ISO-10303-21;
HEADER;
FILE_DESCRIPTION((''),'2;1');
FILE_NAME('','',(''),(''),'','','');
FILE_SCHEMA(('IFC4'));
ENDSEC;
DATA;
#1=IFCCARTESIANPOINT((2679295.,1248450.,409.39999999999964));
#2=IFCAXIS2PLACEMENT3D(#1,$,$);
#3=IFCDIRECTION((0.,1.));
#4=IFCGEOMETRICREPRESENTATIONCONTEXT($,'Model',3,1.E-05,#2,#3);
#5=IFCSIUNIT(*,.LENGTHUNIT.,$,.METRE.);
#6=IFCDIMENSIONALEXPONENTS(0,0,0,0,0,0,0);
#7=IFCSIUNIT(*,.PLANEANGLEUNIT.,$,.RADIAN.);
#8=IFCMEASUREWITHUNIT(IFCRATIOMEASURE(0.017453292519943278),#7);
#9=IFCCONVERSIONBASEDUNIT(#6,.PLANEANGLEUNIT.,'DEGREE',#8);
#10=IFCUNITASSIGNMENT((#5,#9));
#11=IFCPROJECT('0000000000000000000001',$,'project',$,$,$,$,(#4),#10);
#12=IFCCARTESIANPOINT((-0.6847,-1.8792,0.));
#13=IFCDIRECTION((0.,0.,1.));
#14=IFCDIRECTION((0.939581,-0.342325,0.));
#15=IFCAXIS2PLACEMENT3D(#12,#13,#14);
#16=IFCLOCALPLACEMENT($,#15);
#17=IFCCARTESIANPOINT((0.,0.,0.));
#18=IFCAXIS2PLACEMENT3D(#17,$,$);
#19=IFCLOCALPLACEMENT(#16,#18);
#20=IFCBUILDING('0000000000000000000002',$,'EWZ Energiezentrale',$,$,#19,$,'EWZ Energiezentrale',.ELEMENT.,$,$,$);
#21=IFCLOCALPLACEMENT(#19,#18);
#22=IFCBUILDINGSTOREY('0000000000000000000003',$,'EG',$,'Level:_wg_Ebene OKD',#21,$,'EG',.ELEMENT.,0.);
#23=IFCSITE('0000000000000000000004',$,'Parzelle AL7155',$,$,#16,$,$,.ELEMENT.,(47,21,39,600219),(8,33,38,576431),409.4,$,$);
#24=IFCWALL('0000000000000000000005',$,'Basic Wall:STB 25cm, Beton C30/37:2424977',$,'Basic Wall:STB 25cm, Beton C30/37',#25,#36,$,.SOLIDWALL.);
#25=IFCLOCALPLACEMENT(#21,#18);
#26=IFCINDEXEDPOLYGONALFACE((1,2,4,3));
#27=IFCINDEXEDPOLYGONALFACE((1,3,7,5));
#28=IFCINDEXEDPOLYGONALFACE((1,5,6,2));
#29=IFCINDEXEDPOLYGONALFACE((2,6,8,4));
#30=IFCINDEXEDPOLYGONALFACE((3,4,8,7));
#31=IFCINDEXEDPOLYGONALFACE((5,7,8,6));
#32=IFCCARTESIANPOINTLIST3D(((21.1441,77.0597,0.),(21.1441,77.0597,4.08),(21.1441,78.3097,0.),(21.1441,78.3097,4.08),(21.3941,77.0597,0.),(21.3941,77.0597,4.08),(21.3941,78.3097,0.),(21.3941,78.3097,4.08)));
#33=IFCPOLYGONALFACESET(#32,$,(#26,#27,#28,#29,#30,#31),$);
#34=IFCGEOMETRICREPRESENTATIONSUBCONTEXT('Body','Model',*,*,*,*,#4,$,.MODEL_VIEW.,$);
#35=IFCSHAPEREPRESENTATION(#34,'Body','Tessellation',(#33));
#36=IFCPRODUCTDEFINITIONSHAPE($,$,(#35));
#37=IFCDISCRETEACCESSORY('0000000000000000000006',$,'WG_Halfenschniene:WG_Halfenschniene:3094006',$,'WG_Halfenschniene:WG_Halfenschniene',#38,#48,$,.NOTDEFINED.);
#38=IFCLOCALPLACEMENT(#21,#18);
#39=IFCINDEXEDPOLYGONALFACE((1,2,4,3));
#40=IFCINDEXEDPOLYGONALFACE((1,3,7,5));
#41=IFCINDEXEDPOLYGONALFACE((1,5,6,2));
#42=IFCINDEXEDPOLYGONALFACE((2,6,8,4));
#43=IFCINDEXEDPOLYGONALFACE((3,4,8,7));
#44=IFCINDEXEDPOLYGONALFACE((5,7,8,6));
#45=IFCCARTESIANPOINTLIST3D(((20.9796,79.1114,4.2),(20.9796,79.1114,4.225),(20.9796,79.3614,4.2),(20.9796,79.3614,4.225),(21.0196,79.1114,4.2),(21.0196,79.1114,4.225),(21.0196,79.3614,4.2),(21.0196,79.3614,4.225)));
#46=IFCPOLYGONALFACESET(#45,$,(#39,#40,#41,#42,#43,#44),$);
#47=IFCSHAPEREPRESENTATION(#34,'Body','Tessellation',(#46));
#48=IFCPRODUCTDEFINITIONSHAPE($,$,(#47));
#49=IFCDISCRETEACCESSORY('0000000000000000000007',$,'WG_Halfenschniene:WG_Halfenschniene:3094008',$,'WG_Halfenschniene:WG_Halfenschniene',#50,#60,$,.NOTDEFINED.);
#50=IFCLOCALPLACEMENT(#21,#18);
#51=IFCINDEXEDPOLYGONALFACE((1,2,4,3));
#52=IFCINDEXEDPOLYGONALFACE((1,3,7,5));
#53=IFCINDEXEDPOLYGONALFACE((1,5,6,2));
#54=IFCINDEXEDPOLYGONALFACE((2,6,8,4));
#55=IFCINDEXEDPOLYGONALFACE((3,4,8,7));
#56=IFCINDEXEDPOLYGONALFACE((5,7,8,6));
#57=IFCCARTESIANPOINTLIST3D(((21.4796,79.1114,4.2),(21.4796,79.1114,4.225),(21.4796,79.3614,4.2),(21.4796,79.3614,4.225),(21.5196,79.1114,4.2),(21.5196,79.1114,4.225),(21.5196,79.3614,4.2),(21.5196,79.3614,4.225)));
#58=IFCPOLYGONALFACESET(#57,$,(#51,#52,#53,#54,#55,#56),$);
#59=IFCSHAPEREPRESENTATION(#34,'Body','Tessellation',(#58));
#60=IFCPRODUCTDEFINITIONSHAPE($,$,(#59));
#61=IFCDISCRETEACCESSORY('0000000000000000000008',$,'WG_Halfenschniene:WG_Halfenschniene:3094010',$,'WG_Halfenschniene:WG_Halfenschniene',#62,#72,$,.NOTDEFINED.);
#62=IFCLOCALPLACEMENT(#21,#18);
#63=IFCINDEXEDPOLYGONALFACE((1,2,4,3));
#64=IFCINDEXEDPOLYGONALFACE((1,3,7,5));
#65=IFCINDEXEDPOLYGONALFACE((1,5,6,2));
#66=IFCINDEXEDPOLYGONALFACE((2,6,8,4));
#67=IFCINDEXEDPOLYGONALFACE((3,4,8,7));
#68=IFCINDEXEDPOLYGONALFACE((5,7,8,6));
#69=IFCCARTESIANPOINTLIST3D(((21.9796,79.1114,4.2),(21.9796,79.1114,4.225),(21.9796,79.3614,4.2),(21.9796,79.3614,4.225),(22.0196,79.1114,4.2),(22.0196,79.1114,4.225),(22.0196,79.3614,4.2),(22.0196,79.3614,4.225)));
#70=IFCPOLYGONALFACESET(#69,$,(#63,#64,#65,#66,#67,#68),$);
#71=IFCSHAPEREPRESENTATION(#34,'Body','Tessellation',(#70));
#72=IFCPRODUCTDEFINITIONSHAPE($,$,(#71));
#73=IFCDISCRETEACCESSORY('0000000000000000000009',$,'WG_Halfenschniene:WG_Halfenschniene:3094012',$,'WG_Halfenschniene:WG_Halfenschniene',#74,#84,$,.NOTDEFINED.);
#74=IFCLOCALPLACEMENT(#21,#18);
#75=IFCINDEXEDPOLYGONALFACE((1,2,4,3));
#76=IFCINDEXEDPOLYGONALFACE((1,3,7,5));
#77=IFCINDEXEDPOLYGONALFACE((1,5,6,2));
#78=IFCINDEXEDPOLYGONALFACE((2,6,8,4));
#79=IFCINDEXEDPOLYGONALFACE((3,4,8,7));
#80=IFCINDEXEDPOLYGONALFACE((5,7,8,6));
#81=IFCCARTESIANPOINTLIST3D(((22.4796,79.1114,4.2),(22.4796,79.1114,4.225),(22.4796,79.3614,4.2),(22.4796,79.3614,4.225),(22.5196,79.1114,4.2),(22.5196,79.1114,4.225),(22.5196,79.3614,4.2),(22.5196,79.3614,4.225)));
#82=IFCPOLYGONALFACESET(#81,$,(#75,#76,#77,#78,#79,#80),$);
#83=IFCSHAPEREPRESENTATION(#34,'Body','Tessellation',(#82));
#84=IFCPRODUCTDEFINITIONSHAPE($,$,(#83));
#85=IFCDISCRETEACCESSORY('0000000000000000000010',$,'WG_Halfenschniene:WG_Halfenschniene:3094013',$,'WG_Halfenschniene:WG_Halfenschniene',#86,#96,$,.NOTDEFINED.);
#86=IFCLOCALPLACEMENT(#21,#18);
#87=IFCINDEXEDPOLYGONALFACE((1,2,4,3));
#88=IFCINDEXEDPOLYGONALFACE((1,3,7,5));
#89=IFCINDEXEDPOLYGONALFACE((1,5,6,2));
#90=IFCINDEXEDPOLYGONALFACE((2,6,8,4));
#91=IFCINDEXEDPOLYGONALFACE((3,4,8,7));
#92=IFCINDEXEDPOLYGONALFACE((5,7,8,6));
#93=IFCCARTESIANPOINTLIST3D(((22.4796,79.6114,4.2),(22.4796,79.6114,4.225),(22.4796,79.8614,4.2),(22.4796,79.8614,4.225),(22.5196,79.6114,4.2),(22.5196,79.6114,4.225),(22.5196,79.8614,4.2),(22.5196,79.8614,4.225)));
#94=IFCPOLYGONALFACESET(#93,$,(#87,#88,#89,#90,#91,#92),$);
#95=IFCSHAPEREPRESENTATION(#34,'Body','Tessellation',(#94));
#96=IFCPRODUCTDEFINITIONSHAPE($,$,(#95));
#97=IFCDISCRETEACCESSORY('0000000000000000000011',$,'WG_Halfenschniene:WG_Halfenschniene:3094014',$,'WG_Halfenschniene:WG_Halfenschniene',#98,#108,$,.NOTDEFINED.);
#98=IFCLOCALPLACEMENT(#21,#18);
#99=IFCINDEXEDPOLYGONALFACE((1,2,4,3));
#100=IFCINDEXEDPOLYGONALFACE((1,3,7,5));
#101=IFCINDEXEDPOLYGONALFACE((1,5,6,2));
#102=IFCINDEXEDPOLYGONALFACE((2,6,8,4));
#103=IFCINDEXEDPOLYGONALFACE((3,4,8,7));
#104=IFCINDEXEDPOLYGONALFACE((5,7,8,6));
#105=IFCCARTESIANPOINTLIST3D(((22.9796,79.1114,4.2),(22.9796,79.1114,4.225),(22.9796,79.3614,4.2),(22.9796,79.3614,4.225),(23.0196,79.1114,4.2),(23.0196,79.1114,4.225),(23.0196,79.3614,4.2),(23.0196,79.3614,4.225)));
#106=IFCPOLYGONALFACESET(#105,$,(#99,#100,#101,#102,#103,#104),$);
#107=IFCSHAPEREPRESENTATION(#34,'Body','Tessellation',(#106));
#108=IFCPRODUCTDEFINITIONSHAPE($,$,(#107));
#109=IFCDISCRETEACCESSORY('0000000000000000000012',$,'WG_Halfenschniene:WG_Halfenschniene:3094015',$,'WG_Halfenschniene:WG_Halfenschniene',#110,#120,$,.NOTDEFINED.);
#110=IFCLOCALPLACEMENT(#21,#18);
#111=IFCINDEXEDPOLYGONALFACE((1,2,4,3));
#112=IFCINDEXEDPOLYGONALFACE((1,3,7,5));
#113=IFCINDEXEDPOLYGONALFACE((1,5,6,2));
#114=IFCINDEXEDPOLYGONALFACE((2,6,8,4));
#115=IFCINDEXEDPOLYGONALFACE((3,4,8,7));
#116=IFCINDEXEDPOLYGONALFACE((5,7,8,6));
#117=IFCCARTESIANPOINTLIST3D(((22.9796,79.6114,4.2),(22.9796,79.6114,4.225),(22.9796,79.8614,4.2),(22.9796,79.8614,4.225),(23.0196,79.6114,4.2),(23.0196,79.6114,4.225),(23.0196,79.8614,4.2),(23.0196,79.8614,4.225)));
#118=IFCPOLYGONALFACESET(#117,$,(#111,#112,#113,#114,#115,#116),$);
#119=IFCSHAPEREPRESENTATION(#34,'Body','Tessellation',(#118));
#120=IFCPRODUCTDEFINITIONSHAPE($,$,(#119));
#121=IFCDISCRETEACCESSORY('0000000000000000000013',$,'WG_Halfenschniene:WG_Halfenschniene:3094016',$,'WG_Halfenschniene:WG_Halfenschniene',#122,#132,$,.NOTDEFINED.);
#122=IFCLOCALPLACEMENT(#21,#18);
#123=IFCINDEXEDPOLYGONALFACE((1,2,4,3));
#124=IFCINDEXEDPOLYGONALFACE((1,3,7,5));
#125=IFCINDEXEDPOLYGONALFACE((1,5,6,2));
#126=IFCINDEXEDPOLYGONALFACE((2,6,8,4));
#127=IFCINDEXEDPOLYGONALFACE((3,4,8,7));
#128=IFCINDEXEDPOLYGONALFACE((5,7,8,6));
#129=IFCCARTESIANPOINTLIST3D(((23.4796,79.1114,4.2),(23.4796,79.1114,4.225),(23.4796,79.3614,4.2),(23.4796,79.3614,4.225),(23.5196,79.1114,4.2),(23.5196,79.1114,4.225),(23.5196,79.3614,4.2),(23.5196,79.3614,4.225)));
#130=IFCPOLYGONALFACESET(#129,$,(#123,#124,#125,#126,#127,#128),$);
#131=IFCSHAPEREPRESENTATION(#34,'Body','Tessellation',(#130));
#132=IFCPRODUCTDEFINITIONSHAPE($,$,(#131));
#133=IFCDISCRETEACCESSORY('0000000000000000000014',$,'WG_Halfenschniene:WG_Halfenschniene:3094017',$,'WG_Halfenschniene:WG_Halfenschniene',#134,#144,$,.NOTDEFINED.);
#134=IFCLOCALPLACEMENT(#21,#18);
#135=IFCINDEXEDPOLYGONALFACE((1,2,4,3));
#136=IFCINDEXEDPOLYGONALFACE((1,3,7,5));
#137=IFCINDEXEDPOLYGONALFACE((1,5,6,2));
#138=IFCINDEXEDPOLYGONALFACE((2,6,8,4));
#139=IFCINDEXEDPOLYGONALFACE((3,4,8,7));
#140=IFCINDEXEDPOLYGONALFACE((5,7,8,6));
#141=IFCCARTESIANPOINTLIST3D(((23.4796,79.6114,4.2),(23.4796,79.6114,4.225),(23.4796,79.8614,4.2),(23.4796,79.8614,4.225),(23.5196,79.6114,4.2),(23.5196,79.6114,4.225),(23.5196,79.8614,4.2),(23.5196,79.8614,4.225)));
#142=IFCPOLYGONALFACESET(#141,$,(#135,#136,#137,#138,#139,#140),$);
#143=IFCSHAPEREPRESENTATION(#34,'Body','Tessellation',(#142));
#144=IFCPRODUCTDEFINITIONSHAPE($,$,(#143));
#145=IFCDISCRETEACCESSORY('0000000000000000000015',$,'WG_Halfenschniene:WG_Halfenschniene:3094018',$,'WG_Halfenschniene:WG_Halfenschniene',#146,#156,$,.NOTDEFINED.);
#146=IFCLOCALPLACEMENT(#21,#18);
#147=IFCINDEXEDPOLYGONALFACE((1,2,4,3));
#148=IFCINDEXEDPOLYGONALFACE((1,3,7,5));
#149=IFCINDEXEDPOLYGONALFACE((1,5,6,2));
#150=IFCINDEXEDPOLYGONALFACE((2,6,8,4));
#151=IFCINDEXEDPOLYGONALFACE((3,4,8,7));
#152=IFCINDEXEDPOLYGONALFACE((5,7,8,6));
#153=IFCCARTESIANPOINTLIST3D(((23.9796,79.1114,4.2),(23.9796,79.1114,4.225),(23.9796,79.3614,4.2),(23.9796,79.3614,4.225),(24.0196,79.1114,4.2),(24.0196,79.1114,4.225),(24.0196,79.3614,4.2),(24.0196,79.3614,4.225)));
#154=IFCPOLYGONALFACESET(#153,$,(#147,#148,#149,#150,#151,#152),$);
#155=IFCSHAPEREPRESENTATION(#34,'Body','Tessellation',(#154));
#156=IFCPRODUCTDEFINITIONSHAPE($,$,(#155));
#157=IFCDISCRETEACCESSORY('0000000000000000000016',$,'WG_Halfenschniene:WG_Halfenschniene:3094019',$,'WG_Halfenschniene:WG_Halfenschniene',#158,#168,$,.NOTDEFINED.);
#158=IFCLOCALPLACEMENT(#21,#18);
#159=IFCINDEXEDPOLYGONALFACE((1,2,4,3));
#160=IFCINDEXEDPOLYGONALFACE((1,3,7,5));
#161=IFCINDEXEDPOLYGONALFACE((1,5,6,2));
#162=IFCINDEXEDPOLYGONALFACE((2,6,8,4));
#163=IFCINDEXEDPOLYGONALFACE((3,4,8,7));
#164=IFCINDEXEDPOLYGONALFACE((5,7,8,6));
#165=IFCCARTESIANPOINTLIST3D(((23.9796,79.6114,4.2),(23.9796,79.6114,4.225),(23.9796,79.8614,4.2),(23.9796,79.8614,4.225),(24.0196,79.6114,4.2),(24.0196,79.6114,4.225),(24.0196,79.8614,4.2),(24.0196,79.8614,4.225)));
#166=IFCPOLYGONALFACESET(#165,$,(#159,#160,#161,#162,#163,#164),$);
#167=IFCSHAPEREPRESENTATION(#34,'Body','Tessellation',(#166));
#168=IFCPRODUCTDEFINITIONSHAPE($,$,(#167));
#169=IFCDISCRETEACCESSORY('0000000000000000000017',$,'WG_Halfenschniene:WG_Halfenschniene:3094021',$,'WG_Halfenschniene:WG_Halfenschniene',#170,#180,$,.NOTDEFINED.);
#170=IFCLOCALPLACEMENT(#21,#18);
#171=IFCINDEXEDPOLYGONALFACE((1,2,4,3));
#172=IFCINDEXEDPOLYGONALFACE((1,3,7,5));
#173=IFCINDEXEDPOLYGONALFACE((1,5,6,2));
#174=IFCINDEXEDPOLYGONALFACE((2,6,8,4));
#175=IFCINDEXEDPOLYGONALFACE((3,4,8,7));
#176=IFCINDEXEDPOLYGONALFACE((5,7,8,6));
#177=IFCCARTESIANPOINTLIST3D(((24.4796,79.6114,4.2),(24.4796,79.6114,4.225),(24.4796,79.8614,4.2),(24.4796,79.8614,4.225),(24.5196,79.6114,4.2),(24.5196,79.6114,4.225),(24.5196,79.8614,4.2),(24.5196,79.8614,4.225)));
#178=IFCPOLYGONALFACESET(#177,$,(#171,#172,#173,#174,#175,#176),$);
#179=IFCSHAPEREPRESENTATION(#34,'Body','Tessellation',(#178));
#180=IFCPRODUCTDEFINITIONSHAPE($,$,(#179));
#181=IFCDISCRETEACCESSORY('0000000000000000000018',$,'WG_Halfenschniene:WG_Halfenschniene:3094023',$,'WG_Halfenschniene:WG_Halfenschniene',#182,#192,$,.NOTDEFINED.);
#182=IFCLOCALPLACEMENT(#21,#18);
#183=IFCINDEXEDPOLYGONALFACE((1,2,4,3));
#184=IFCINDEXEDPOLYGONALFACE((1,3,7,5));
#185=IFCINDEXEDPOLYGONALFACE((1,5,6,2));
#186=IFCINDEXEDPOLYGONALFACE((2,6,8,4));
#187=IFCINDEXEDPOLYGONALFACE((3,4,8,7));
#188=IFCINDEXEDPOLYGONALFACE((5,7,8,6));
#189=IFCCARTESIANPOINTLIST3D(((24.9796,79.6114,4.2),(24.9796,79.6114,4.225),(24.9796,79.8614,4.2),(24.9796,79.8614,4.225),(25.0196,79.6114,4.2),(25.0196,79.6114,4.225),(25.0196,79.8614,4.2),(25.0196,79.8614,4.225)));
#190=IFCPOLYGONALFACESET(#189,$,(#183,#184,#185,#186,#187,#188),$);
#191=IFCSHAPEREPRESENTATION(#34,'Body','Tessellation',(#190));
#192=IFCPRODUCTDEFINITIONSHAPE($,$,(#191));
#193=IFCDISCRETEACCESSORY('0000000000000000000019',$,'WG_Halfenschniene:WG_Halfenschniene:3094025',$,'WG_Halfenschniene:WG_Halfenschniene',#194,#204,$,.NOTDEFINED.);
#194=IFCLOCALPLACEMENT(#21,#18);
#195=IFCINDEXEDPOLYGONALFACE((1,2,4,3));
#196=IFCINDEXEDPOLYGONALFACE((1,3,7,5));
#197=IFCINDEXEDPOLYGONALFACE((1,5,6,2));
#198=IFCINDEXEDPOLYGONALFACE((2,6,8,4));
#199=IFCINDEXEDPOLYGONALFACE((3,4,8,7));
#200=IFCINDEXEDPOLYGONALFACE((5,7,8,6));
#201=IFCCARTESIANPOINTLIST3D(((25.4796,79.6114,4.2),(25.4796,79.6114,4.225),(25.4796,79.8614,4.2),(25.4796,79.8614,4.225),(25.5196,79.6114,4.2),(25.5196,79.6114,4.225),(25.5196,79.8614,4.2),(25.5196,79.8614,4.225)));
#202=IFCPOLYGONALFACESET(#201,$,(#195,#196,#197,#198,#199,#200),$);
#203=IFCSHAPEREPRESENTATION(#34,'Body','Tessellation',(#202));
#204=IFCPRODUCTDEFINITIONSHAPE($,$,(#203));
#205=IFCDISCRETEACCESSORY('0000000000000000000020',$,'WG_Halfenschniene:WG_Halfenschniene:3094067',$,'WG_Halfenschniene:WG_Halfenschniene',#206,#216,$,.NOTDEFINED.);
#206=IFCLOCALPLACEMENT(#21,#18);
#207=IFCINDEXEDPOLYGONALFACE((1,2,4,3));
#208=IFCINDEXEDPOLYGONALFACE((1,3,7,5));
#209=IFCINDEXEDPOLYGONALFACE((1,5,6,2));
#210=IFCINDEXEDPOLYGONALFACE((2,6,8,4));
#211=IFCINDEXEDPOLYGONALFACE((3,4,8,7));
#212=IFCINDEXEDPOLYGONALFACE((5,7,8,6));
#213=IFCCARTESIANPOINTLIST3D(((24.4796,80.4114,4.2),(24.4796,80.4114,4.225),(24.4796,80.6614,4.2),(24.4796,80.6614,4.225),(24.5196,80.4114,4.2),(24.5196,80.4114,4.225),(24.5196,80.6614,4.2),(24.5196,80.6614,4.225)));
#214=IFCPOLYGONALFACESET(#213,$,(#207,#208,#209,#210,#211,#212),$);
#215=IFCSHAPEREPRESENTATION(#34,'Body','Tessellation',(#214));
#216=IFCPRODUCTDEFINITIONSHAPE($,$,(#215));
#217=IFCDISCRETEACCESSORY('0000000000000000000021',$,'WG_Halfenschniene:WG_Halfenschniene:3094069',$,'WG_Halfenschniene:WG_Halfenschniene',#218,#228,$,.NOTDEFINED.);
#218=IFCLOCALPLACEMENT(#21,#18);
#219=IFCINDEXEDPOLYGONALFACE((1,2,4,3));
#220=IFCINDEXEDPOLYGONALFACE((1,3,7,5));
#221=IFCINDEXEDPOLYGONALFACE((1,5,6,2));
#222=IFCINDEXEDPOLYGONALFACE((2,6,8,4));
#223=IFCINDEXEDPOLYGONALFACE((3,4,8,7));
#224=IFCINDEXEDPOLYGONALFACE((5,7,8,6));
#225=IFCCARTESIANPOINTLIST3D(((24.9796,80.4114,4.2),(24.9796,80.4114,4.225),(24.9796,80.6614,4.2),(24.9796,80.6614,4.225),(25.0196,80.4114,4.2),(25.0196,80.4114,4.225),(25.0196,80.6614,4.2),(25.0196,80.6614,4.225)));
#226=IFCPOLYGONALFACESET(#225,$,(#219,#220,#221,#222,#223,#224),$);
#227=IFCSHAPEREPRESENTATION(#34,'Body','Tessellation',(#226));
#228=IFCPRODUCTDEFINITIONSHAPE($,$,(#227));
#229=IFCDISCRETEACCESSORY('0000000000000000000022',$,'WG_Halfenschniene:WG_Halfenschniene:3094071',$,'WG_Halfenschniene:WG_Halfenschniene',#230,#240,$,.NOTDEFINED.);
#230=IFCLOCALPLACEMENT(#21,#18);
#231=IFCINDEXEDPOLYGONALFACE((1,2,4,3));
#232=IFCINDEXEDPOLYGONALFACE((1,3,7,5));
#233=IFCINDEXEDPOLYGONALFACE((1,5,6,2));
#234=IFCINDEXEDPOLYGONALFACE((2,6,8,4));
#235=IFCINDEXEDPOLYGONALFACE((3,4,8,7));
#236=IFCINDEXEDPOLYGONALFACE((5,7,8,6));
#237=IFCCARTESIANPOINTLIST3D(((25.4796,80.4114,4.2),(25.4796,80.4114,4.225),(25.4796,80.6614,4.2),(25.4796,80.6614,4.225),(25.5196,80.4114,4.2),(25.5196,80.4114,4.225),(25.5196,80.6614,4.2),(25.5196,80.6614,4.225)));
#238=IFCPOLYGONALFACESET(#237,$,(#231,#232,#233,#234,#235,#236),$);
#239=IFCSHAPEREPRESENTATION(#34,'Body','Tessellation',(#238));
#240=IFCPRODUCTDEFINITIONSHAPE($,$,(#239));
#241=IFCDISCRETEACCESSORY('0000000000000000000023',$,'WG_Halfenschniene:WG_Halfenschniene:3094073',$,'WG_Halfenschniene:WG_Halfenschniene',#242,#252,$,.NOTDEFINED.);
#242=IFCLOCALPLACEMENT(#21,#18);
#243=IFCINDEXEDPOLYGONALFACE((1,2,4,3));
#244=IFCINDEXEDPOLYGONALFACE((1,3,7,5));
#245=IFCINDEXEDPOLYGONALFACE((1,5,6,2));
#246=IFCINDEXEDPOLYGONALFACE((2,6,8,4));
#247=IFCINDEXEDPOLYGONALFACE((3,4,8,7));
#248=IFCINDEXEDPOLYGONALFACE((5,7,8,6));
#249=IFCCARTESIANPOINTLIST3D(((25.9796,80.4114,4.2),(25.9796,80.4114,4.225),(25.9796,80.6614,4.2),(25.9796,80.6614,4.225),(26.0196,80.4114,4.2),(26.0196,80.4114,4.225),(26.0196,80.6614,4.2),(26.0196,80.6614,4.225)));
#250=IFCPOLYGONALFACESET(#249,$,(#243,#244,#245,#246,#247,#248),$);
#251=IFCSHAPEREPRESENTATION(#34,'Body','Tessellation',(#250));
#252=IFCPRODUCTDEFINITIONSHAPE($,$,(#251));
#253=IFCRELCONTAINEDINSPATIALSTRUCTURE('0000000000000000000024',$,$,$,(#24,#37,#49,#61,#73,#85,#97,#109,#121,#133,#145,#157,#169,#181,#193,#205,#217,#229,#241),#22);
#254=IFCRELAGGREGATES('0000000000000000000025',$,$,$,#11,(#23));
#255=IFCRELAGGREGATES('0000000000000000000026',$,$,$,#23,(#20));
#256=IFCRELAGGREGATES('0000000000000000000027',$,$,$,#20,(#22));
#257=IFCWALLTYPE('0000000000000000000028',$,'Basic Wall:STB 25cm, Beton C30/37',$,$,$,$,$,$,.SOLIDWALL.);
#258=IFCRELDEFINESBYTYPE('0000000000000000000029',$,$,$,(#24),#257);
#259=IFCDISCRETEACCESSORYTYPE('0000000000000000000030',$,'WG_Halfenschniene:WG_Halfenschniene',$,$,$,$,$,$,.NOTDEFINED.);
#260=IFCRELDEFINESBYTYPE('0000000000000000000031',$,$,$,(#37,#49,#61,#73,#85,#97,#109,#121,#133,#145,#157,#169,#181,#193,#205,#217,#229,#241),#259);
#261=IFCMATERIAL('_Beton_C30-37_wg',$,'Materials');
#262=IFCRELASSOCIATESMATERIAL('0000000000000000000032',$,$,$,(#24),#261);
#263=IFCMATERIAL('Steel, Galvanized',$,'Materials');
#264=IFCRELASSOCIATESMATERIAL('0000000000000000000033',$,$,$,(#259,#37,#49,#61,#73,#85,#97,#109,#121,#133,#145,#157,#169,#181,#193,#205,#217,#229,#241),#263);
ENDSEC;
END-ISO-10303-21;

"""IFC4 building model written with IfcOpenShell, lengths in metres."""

from ifc_helpers import new_model, entity, si_unit, converted_unit, direction, frame, origin, place, context, subcontext, project, spatial, indexed_curve, outline, extrude, source, transform, mapped, material, type_object, element, save


model = new_model("IFC4")

# Units and contexts
model_context = context("Model", 3, precision=1e-05, world=frame((2679295.0, 1248450.0, 409.39999999999964)), true_north=direction((0.0, 1.0)))
body_context = subcontext(model_context, "Body", "Model", "MODEL_VIEW")
ifc_project = project(units=[si_unit("LENGTHUNIT", "METRE"), converted_unit("PLANEANGLEUNIT", "DEGREE", entity("IfcRatioMeasure", 0.017453292519943278), si_unit("PLANEANGLEUNIT", "RADIAN"), dimensions=[0, 0, 0, 0, 0, 0, 0])], contexts=[model_context])

# Site, building, storey
site_placement = place(None, frame((-0.6847, -1.8792, 0.0), z_axis=(0.0, 0.0, 1.0), x_axis=(0.939581, -0.342325, 0.0)))
site = spatial("IfcSite", under=ifc_project, at=site_placement, Name="Parzelle AL7155", CompositionType="ELEMENT", RefLatitude=(47, 21, 39, 600219), RefLongitude=(8, 33, 38, 576431), RefElevation=409.4)
building_placement = place(site_placement, origin())
building = spatial("IfcBuilding", under=site, at=building_placement, Name="EWZ Energiezentrale", LongName="EWZ Energiezentrale", CompositionType="ELEMENT")
storey_placement = place(building_placement, origin())
storey = spatial("IfcBuildingStorey", under=building, at=storey_placement, Name="EG", ObjectType="Level:_wg_Ebene OKD", LongName="EG", CompositionType="ELEMENT", Elevation=0.0)

# Wall
ifc_material_1 = material(Name="_Beton_C30-37_wg", Category="Materials")
wall_type = type_object("IfcWallType", Name="Basic Wall:STB 25cm, Beton C30/37", PredefinedType="SOLIDWALL")
wall_placement = place(storey_placement, frame((21.2691, 78.3097, 0.0), z_axis=(0.0, 0.0, 1.0), x_axis=(0.0, -1.0, 0.0)))
element("IfcWall", 1, at=wall_placement, inside=storey, type_object=wall_type, material=ifc_material_1, Name="Basic Wall:STB 25cm, Beton C30/37:2424977", ObjectType="Basic Wall:STB 25cm, Beton C30/37", PredefinedType="SOLIDWALL", context=body_context, shape_type="SweptSolid", body=[
    extrude(outline(indexed_curve([(1.25, 0.125), (0.0, 0.125), (0.0, -0.125), (1.25, -0.125), (1.25, 0.125)], self_intersect=False)), origin(), (0.0, 0.0, 1.0), 4.08),
])

# Discrete accessories
ifc_material_2 = material(Name="Steel, Galvanized", Category="Materials")
discrete_accessory_type = type_object("IfcDiscreteAccessoryType", Name="WG_Halfenschniene:WG_Halfenschniene", PredefinedType="NOTDEFINED", material=ifc_material_2)
shared_shape = source(origin(), body_context, "Body", "SweptSolid", [
    extrude(outline(indexed_curve([(-0.125, -0.02), (0.125, -0.02), (0.125, 0.02), (-0.125, 0.02), (-0.125, -0.02)], self_intersect=False)), frame((0.125, 0.0, -0.0125)), (0.0, 0.0, 1.0), 0.025),
])
for number, where, z_axis, x_axis, name in (
    (2, (20.9996, 79.1114, 4.2125), (0.0, 0.0, -1.0), (0.0, 1.0, 0.0), "WG_Halfenschniene:WG_Halfenschniene:3094006"),
    (3, (21.4996, 79.1114, 4.2125), (0.0, 0.0, -1.0), (0.0, 1.0, 0.0), "WG_Halfenschniene:WG_Halfenschniene:3094008"),
    (4, (21.9996, 79.1114, 4.2125), (0.0, 0.0, -1.0), (0.0, 1.0, 0.0), "WG_Halfenschniene:WG_Halfenschniene:3094010"),
    (5, (22.4996, 79.1114, 4.2125), (0.0, 0.0, -1.0), (0.0, 1.0, 0.0), "WG_Halfenschniene:WG_Halfenschniene:3094012"),
    (6, (22.4996, 79.6114, 4.2125), (0.0, 0.0, -1.0), (0.0, 1.0, 0.0), "WG_Halfenschniene:WG_Halfenschniene:3094013"),
    (7, (22.9996, 79.1114, 4.2125), (0.0, 0.0, -1.0), (0.0, 1.0, 0.0), "WG_Halfenschniene:WG_Halfenschniene:3094014"),
    (8, (22.9996, 79.6114, 4.2125), (0.0, 0.0, -1.0), (0.0, 1.0, 0.0), "WG_Halfenschniene:WG_Halfenschniene:3094015"),
    (9, (23.4996, 79.1114, 4.2125), (0.0, 0.0, -1.0), (0.0, 1.0, 0.0), "WG_Halfenschniene:WG_Halfenschniene:3094016"),
    (10, (23.4996, 79.6114, 4.2125), (0.0, 0.0, -1.0), (0.0, 1.0, 0.0), "WG_Halfenschniene:WG_Halfenschniene:3094017"),
    (11, (23.9996, 79.1114, 4.2125), (0.0, 0.0, -1.0), (0.0, 1.0, 0.0), "WG_Halfenschniene:WG_Halfenschniene:3094018"),
    (12, (23.9996, 79.6114, 4.2125), (0.0, 0.0, -1.0), (0.0, 1.0, 0.0), "WG_Halfenschniene:WG_Halfenschniene:3094019"),
    (13, (24.4996, 79.6114, 4.2125), (0.0, 0.0, -1.0), (0.0, 1.0, 0.0), "WG_Halfenschniene:WG_Halfenschniene:3094021"),
    (14, (24.9996, 79.6114, 4.2125), (0.0, 0.0, -1.0), (0.0, 1.0, 0.0), "WG_Halfenschniene:WG_Halfenschniene:3094023"),
    (15, (25.4996, 79.6114, 4.2125), (0.0, 0.0, -1.0), (0.0, 1.0, 0.0), "WG_Halfenschniene:WG_Halfenschniene:3094025"),
    (16, (24.4996, 80.4114, 4.2125), (0.0, 0.0, -1.0), (0.0, 1.0, 0.0), "WG_Halfenschniene:WG_Halfenschniene:3094067"),
    (17, (24.9996, 80.4114, 4.2125), (0.0, 0.0, -1.0), (0.0, 1.0, 0.0), "WG_Halfenschniene:WG_Halfenschniene:3094069"),
    (18, (25.4996, 80.4114, 4.2125), (0.0, 0.0, -1.0), (0.0, 1.0, 0.0), "WG_Halfenschniene:WG_Halfenschniene:3094071"),
    (19, (25.9996, 80.4114, 4.2125), (0.0, 0.0, -1.0), (0.0, 1.0, 0.0), "WG_Halfenschniene:WG_Halfenschniene:3094073"),
):
    element("IfcDiscreteAccessory", number, at=place(storey_placement, frame(where, z_axis=z_axis, x_axis=x_axis)), inside=storey, type_object=discrete_accessory_type, material=ifc_material_2, Name=name, ObjectType="WG_Halfenschniene:WG_Halfenschniene", PredefinedType="NOTDEFINED", context=body_context, shape_type="MappedRepresentation", body=[
        mapped(shared_shape, transform((0.0, 0.0, 0.0), scale=1.0)),
    ])

save(model, "model.ifc")
